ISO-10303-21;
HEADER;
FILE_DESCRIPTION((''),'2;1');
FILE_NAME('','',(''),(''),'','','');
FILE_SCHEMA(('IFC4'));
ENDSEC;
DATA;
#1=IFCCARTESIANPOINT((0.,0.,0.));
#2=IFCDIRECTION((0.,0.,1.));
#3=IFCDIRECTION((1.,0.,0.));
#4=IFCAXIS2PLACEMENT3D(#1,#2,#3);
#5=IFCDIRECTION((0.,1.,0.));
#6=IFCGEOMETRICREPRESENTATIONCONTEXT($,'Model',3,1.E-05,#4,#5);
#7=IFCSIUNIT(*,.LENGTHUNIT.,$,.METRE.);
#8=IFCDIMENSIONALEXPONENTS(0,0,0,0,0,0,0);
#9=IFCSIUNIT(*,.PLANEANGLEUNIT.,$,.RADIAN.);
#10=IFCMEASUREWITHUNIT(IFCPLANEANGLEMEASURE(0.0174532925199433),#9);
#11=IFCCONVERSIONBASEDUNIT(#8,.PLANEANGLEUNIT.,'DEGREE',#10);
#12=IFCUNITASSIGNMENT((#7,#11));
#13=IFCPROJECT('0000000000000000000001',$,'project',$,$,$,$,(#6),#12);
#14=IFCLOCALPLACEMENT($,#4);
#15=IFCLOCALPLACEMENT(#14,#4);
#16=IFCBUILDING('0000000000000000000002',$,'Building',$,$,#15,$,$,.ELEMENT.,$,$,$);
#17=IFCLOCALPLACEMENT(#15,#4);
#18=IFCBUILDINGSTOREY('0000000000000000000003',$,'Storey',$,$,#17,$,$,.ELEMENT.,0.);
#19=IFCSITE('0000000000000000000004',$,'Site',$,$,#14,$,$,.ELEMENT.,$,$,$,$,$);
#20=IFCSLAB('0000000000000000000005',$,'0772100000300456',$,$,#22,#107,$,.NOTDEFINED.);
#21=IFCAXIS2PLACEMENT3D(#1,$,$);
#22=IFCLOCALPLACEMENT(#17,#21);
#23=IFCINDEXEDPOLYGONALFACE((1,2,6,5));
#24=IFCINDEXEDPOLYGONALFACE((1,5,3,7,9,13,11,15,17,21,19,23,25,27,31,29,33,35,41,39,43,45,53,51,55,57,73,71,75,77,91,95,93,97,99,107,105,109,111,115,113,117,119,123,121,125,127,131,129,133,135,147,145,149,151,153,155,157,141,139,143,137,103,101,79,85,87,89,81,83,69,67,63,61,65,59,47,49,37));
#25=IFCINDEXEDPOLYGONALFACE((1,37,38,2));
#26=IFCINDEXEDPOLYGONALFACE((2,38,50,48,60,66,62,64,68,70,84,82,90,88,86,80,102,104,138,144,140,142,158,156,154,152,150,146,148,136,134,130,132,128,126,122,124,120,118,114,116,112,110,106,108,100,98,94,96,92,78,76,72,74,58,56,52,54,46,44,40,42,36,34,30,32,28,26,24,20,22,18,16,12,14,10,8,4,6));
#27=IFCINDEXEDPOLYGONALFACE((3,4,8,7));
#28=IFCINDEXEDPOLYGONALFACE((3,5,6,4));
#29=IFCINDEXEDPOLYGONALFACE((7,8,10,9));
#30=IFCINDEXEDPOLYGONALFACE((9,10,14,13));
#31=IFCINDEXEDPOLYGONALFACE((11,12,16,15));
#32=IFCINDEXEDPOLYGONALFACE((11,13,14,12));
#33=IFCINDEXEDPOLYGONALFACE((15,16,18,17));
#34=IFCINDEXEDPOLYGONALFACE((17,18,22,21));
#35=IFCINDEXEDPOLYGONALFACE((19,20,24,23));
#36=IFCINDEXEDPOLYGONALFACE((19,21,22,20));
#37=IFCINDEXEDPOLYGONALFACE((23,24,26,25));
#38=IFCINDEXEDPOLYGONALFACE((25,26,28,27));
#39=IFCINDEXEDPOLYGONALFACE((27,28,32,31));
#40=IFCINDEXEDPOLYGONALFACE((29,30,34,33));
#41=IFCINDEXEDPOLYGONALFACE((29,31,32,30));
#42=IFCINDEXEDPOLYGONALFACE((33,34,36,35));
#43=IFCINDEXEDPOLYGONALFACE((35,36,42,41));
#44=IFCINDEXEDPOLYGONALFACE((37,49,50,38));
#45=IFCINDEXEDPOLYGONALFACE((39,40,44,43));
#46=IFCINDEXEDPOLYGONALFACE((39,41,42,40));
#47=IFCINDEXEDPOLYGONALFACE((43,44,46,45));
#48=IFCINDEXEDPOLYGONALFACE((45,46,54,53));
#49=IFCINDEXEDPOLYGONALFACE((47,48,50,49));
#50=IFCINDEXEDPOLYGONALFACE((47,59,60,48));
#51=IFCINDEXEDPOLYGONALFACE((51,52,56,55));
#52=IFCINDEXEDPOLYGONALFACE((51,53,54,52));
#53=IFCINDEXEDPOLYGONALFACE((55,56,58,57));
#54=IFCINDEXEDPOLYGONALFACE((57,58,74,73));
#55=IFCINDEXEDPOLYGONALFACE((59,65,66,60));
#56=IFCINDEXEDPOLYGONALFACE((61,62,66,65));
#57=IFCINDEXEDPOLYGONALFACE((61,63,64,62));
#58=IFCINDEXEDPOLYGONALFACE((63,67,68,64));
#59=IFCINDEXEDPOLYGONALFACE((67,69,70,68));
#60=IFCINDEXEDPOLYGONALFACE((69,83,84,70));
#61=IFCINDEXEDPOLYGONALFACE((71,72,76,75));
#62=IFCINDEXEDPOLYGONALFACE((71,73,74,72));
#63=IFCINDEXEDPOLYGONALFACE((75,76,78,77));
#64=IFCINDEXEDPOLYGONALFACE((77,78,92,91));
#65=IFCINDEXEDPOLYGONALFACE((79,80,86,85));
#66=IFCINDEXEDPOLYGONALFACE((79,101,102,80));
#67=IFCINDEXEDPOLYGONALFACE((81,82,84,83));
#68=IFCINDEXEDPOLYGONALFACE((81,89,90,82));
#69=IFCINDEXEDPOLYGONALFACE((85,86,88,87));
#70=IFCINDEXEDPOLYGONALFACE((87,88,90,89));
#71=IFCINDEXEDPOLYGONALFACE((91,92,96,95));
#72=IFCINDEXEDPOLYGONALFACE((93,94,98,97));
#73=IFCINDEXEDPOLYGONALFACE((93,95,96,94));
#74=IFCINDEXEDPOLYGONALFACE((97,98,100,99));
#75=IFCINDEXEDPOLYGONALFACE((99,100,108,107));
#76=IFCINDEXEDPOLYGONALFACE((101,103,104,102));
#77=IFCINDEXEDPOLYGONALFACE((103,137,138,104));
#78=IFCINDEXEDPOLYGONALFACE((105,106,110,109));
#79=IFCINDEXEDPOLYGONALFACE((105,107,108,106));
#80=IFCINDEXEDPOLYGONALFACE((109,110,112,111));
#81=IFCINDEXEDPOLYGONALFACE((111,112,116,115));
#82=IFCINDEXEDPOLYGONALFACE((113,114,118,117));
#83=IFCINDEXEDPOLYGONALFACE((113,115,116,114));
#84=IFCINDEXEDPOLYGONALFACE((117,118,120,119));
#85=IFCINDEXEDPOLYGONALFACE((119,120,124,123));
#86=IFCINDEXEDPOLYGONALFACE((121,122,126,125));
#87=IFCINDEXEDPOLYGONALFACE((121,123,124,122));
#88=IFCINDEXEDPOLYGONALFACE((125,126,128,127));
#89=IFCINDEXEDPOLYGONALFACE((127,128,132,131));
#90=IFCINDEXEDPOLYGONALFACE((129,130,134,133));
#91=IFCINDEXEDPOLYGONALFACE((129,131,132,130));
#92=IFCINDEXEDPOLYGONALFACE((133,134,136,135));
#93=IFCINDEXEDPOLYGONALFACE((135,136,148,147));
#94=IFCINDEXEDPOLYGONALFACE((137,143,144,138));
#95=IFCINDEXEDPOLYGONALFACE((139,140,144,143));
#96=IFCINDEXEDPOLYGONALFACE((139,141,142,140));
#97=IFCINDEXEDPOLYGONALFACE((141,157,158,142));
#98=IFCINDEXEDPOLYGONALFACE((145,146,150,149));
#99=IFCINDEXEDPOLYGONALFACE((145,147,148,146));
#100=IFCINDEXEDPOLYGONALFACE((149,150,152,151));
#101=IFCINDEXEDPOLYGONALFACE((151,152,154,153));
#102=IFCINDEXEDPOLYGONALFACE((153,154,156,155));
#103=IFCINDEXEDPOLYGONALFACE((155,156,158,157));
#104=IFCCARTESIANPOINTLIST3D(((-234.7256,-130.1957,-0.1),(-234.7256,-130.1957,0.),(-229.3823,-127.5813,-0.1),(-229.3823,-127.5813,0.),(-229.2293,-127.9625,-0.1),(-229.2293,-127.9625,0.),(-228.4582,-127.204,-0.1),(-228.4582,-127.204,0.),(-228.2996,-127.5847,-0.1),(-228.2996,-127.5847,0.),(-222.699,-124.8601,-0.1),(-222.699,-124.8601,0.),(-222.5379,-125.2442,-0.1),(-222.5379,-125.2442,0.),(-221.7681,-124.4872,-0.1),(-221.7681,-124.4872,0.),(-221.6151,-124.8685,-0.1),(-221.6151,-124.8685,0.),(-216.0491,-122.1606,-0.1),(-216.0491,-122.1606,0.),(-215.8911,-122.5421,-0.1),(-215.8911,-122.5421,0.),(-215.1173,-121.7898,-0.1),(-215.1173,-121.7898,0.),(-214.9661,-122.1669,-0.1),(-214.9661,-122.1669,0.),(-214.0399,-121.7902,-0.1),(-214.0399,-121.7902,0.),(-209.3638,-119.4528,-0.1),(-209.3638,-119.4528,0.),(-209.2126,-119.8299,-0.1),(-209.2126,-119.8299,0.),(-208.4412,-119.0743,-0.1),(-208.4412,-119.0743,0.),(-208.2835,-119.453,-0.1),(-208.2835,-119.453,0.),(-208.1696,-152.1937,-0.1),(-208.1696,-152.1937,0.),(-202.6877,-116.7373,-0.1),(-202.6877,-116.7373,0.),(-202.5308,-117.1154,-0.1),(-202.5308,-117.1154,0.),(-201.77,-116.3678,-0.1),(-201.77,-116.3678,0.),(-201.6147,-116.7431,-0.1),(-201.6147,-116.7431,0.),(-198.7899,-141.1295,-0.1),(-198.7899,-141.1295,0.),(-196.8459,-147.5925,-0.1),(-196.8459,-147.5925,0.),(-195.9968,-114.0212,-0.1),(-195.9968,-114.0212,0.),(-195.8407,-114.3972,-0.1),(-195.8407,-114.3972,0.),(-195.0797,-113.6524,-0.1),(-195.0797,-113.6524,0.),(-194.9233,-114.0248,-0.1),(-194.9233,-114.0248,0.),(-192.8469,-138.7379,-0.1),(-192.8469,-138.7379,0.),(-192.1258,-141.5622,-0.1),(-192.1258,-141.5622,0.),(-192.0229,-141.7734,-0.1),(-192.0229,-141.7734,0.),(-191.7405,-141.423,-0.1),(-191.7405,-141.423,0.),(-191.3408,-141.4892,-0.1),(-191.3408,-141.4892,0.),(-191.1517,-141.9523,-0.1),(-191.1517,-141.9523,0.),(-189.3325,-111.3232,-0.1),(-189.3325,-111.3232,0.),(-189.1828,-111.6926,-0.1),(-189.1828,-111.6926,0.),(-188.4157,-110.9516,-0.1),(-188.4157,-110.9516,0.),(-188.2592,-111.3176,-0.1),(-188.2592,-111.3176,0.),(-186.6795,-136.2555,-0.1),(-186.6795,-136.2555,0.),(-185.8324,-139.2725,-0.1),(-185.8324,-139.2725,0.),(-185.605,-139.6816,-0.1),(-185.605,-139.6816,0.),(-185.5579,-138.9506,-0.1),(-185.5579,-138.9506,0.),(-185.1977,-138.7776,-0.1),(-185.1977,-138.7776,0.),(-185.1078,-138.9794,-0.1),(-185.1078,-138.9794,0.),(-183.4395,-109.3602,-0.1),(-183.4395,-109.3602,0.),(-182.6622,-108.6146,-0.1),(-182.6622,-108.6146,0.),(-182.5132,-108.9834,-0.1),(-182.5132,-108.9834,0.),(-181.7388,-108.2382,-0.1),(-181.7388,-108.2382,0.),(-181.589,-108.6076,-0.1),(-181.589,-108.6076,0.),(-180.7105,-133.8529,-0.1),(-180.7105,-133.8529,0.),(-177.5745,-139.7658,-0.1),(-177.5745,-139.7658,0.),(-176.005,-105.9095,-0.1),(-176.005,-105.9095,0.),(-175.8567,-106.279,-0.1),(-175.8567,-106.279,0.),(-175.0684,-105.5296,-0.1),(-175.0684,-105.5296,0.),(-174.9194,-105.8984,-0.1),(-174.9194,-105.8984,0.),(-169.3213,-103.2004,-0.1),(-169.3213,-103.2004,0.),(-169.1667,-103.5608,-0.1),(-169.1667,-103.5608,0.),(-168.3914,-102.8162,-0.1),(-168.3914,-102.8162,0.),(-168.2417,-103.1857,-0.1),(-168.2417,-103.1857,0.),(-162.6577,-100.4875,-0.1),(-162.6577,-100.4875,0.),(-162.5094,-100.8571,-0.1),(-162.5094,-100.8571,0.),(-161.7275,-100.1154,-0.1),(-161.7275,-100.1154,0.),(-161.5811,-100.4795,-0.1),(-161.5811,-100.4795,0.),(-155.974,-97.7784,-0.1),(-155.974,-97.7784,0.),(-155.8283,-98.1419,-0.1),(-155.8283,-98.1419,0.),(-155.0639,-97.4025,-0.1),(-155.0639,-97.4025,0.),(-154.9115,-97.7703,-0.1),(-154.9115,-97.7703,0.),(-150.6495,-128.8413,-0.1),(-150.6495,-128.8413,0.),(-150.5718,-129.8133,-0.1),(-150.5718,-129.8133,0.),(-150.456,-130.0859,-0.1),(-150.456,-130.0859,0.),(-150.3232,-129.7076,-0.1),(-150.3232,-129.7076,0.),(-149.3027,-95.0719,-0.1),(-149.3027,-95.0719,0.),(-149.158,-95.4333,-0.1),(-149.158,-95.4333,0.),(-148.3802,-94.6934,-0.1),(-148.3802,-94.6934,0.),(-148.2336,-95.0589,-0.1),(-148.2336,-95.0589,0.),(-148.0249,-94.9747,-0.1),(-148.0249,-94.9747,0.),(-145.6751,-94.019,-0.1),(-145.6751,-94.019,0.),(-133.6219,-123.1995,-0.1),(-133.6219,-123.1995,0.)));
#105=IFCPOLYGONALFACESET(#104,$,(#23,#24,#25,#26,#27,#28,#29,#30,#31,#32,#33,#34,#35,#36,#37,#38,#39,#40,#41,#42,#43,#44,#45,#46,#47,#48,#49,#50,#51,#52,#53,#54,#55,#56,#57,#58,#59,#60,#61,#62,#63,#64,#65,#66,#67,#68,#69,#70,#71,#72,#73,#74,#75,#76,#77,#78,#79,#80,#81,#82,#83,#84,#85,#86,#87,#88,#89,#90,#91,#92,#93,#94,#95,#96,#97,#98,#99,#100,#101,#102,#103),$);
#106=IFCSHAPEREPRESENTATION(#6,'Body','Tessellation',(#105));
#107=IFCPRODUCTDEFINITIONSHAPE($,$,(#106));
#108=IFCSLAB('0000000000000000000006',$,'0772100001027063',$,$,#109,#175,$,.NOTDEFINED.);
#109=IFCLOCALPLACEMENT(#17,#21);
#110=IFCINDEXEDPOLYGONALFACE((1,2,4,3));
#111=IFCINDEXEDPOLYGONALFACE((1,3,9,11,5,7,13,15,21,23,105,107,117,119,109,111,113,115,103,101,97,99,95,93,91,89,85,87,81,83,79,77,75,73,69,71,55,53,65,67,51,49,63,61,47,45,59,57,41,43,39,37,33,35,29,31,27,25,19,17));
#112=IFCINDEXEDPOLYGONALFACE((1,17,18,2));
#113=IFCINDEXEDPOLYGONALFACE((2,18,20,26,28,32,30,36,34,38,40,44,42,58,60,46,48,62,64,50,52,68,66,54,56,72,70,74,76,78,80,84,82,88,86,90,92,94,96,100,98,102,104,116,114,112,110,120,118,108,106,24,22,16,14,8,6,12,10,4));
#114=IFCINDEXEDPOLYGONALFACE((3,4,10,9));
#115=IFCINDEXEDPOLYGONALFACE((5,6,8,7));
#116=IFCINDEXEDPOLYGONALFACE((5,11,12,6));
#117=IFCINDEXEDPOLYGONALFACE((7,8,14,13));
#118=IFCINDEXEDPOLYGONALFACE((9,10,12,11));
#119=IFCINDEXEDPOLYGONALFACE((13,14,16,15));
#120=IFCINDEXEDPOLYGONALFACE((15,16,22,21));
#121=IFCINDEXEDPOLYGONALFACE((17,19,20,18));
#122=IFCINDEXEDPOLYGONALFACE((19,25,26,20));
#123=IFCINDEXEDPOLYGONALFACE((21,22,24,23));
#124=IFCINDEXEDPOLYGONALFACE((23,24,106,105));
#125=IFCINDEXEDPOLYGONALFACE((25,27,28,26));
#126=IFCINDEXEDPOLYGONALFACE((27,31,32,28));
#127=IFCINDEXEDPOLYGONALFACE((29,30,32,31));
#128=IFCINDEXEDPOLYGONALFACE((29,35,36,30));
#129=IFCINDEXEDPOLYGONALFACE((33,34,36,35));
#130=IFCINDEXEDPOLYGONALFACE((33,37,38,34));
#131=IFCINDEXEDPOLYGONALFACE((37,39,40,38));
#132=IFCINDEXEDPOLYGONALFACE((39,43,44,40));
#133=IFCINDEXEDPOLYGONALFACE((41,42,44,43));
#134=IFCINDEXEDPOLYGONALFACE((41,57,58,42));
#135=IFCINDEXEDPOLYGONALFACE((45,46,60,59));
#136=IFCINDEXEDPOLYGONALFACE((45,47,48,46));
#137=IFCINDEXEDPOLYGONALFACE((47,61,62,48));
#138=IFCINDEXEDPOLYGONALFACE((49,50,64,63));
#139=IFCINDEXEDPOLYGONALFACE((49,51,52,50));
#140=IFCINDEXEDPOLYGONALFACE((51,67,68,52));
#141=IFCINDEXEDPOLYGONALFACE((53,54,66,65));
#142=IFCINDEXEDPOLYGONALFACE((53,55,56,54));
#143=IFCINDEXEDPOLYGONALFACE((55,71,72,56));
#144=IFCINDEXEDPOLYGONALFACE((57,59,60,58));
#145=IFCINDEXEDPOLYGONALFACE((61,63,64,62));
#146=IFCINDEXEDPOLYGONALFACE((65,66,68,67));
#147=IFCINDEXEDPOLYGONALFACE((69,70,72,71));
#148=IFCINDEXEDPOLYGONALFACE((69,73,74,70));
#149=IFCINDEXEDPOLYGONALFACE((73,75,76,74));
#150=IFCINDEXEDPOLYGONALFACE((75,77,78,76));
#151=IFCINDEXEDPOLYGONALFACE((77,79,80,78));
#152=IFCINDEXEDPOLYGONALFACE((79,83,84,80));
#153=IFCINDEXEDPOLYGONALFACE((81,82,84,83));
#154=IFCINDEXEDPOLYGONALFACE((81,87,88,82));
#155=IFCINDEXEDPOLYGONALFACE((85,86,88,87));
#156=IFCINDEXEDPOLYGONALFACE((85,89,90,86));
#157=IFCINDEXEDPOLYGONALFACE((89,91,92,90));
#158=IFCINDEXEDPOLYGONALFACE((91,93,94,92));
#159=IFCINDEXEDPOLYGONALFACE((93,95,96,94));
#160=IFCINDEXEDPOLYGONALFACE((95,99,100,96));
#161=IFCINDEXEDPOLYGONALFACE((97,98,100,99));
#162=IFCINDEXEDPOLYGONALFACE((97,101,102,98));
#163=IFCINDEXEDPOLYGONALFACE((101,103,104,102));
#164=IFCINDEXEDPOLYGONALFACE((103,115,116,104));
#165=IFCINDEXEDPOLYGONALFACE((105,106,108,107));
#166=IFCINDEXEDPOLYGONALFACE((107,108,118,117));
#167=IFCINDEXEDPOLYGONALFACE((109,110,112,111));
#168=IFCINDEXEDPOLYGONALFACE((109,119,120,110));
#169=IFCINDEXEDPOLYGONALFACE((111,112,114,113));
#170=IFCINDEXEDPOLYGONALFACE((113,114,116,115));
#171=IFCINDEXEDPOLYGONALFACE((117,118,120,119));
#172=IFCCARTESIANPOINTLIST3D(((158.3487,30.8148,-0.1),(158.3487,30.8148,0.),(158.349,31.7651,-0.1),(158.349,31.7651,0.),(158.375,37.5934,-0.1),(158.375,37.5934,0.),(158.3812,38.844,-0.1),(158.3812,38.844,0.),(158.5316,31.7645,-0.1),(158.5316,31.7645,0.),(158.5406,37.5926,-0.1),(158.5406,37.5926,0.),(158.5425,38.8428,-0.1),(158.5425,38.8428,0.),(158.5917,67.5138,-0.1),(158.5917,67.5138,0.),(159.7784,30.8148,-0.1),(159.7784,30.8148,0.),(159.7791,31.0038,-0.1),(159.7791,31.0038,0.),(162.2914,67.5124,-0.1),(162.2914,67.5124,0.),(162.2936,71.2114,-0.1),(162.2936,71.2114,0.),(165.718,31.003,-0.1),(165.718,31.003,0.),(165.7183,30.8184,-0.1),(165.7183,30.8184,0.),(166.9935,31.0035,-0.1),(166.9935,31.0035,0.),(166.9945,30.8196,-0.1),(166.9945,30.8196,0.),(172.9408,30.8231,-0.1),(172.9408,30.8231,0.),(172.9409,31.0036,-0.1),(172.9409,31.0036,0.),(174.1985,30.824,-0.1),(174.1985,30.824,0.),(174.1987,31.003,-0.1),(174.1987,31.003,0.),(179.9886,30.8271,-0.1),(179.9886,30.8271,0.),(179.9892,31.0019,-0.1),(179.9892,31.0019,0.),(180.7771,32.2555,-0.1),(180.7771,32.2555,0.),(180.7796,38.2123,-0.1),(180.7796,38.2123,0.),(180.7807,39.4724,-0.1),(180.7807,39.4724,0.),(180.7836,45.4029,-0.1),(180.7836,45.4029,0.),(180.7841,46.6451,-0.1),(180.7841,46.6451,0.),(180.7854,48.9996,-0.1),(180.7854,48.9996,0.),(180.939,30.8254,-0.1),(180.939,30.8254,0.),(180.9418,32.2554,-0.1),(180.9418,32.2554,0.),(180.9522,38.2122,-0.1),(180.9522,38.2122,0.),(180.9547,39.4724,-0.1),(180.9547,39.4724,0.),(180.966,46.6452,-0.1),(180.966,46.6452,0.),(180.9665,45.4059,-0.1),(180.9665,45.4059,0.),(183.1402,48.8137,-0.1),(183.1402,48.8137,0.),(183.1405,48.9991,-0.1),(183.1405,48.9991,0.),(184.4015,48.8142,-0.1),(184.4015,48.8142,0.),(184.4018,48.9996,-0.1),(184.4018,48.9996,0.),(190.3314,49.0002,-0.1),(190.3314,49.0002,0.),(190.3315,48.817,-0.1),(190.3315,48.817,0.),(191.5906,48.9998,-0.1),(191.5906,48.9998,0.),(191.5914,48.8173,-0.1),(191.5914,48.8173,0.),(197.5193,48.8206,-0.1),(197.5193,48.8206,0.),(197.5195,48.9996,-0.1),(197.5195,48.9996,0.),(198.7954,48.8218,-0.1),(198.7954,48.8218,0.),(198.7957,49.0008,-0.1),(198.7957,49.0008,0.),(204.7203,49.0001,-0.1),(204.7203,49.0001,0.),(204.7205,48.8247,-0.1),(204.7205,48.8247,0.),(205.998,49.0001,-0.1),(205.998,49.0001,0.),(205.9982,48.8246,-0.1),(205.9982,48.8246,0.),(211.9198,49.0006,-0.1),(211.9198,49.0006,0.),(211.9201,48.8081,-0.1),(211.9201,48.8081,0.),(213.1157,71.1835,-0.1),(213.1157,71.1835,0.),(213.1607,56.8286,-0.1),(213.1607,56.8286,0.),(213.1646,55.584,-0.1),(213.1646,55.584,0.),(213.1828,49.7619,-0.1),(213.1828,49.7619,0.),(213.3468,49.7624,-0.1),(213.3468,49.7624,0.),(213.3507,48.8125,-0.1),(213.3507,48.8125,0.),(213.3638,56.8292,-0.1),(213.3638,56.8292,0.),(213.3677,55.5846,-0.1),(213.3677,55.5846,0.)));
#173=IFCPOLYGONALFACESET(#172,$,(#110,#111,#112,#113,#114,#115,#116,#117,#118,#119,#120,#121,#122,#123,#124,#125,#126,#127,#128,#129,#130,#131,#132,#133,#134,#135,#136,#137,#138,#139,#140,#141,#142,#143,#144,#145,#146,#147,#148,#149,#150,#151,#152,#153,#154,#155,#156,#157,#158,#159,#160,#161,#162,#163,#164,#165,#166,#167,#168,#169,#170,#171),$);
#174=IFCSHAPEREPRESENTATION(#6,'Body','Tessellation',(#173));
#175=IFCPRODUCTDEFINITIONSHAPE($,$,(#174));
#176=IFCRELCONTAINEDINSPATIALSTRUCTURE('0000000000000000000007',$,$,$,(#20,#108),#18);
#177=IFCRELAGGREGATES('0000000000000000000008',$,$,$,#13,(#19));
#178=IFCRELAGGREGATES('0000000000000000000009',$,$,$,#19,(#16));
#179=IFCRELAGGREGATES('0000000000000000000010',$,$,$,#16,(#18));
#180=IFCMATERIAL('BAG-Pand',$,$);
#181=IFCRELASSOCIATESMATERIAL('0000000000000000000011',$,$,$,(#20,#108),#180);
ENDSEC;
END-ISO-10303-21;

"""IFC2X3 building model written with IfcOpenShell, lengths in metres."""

from ifc_helpers import new_model, entity, si_unit, converted_unit, direction, frame, origin_with_axes, place, context, project, spatial, polyline, outline, extrude, material, element, save


model = new_model("IFC2X3")

# Units and contexts
model_context = context("Model", 3, precision=1e-05, world=origin_with_axes(), true_north=direction((0.0, 1.0, 0.0)))
ifc_project = project(units=[si_unit("LENGTHUNIT", "METRE"), converted_unit("PLANEANGLEUNIT", "DEGREE", entity("IfcPlaneAngleMeasure", 0.0174532925199433), si_unit("PLANEANGLEUNIT", "RADIAN"), dimensions=[0, 0, 0, 0, 0, 0, 0])], contexts=[model_context])

# Site, building, storey
site_placement = place(None, origin_with_axes())
site = spatial("IfcSite", under=ifc_project, at=site_placement, Name="Site", CompositionType="ELEMENT")
building_placement = place(site_placement, origin_with_axes())
building = spatial("IfcBuilding", under=site, at=building_placement, Name="Building", CompositionType="ELEMENT")
storey_placement = place(building_placement, origin_with_axes())
storey = spatial("IfcBuildingStorey", under=building, at=storey_placement, Name="Storey", CompositionType="ELEMENT", Elevation=0.0)

# Slabs
ifc_material = material(Name="BAG-Pand")
slab_1_placement = place(storey_placement, frame((0.0, 0.0, -0.1), z_axis=(0.0, 0.0, 1.0), x_axis=(1.0, 0.0, 0.0)))
element("IfcSlab", 1, at=slab_1_placement, inside=storey, material=ifc_material, Name="0772100000300456", PredefinedType="NOTDEFINED", context=model_context, shape_type="SweptSolid", body=[
    extrude(outline(polyline([(-229.2293, -127.9625), (-229.3823, -127.5813), (-228.4582, -127.204), (-228.2996, -127.5847), (-222.5379, -125.2442), (-222.699, -124.8601), (-221.7681, -124.4872), (-221.6151, -124.8685), (-215.8911, -122.5421), (-216.0491, -122.1606), (-215.1173, -121.7898), (-214.9661, -122.1669), (-214.0399, -121.7902), (-209.2126, -119.8299), (-209.3638, -119.4528), (-208.4412, -119.0743), (-208.2835, -119.453), (-202.5308, -117.1154), (-202.6877, -116.7373), (-201.77, -116.3678), (-201.6147, -116.7431), (-195.8407, -114.3972), (-195.9968, -114.0212), (-195.0797, -113.6524), (-194.9233, -114.0248), (-189.1828, -111.6926), (-189.3325, -111.3232), (-188.4157, -110.9516), (-188.2592, -111.3176), (-183.4395, -109.3602), (-182.5132, -108.9834), (-182.6622, -108.6146), (-181.7388, -108.2382), (-181.589, -108.6076), (-175.8567, -106.279), (-176.005, -105.9095), (-175.0684, -105.5296), (-174.9194, -105.8984), (-169.1667, -103.5608), (-169.3213, -103.2004), (-168.3914, -102.8162), (-168.2417, -103.1857), (-162.5094, -100.8571), (-162.6577, -100.4875), (-161.7275, -100.1154), (-161.5811, -100.4795), (-155.8283, -98.1419), (-155.974, -97.7784), (-155.0639, -97.4025), (-154.9115, -97.7703), (-149.158, -95.4333), (-149.3027, -95.0719), (-148.3802, -94.6934), (-148.2336, -95.0589), (-148.0249, -94.9747), (-145.6751, -94.019), (-133.6219, -123.1995), (-150.456, -130.0859), (-150.5718, -129.8133), (-150.3232, -129.7076), (-150.6495, -128.8413), (-177.5745, -139.7658), (-180.7105, -133.8529), (-186.6795, -136.2555), (-185.5579, -138.9506), (-185.1977, -138.7776), (-185.1078, -138.9794), (-185.8324, -139.2725), (-185.605, -139.6816), (-191.1517, -141.9523), (-191.3408, -141.4892), (-192.0229, -141.7734), (-192.1258, -141.5622), (-191.7405, -141.423), (-192.8469, -138.7379), (-198.7899, -141.1295), (-196.8459, -147.5925), (-208.1696, -152.1937), (-234.7256, -130.1957), (-229.2293, -127.9625)])), origin_with_axes(), (0.0, 0.0, 1.0), 0.1),
])
slab_2_placement = place(storey_placement, frame((0.0, 0.0, -0.1), z_axis=(0.0, 0.0, 1.0), x_axis=(1.0, 0.0, 0.0)))
element("IfcSlab", 2, at=slab_2_placement, inside=storey, material=ifc_material, Name="0772100001027063", PredefinedType="NOTDEFINED", context=model_context, shape_type="SweptSolid", body=[
    extrude(outline(polyline([(158.349, 31.7651), (158.5316, 31.7645), (158.5406, 37.5926), (158.375, 37.5934), (158.3812, 38.844), (158.5425, 38.8428), (158.5917, 67.5138), (162.2914, 67.5124), (162.2936, 71.2114), (213.1157, 71.1835), (213.1607, 56.8286), (213.3638, 56.8292), (213.3677, 55.5846), (213.1646, 55.584), (213.1828, 49.7619), (213.3468, 49.7624), (213.3507, 48.8125), (211.9201, 48.8081), (211.9198, 49.0006), (205.998, 49.0001), (205.9982, 48.8246), (204.7205, 48.8247), (204.7203, 49.0001), (198.7957, 49.0008), (198.7954, 48.8218), (197.5193, 48.8206), (197.5195, 48.9996), (191.5906, 48.9998), (191.5914, 48.8173), (190.3315, 48.817), (190.3314, 49.0002), (184.4018, 48.9996), (184.4015, 48.8142), (183.1402, 48.8137), (183.1405, 48.9991), (180.7854, 48.9996), (180.7841, 46.6451), (180.966, 46.6452), (180.9665, 45.4059), (180.7836, 45.4029), (180.7807, 39.4724), (180.9547, 39.4724), (180.9522, 38.2122), (180.7796, 38.2123), (180.7771, 32.2555), (180.9418, 32.2554), (180.939, 30.8254), (179.9886, 30.8271), (179.9892, 31.0019), (174.1987, 31.003), (174.1985, 30.824), (172.9408, 30.8231), (172.9409, 31.0036), (166.9935, 31.0035), (166.9945, 30.8196), (165.7183, 30.8184), (165.718, 31.003), (159.7791, 31.0038), (159.7784, 30.8148), (158.3487, 30.8148), (158.349, 31.7651)])), origin_with_axes(), (0.0, 0.0, 1.0), 0.1),
])

save(model, "model.ifc")
